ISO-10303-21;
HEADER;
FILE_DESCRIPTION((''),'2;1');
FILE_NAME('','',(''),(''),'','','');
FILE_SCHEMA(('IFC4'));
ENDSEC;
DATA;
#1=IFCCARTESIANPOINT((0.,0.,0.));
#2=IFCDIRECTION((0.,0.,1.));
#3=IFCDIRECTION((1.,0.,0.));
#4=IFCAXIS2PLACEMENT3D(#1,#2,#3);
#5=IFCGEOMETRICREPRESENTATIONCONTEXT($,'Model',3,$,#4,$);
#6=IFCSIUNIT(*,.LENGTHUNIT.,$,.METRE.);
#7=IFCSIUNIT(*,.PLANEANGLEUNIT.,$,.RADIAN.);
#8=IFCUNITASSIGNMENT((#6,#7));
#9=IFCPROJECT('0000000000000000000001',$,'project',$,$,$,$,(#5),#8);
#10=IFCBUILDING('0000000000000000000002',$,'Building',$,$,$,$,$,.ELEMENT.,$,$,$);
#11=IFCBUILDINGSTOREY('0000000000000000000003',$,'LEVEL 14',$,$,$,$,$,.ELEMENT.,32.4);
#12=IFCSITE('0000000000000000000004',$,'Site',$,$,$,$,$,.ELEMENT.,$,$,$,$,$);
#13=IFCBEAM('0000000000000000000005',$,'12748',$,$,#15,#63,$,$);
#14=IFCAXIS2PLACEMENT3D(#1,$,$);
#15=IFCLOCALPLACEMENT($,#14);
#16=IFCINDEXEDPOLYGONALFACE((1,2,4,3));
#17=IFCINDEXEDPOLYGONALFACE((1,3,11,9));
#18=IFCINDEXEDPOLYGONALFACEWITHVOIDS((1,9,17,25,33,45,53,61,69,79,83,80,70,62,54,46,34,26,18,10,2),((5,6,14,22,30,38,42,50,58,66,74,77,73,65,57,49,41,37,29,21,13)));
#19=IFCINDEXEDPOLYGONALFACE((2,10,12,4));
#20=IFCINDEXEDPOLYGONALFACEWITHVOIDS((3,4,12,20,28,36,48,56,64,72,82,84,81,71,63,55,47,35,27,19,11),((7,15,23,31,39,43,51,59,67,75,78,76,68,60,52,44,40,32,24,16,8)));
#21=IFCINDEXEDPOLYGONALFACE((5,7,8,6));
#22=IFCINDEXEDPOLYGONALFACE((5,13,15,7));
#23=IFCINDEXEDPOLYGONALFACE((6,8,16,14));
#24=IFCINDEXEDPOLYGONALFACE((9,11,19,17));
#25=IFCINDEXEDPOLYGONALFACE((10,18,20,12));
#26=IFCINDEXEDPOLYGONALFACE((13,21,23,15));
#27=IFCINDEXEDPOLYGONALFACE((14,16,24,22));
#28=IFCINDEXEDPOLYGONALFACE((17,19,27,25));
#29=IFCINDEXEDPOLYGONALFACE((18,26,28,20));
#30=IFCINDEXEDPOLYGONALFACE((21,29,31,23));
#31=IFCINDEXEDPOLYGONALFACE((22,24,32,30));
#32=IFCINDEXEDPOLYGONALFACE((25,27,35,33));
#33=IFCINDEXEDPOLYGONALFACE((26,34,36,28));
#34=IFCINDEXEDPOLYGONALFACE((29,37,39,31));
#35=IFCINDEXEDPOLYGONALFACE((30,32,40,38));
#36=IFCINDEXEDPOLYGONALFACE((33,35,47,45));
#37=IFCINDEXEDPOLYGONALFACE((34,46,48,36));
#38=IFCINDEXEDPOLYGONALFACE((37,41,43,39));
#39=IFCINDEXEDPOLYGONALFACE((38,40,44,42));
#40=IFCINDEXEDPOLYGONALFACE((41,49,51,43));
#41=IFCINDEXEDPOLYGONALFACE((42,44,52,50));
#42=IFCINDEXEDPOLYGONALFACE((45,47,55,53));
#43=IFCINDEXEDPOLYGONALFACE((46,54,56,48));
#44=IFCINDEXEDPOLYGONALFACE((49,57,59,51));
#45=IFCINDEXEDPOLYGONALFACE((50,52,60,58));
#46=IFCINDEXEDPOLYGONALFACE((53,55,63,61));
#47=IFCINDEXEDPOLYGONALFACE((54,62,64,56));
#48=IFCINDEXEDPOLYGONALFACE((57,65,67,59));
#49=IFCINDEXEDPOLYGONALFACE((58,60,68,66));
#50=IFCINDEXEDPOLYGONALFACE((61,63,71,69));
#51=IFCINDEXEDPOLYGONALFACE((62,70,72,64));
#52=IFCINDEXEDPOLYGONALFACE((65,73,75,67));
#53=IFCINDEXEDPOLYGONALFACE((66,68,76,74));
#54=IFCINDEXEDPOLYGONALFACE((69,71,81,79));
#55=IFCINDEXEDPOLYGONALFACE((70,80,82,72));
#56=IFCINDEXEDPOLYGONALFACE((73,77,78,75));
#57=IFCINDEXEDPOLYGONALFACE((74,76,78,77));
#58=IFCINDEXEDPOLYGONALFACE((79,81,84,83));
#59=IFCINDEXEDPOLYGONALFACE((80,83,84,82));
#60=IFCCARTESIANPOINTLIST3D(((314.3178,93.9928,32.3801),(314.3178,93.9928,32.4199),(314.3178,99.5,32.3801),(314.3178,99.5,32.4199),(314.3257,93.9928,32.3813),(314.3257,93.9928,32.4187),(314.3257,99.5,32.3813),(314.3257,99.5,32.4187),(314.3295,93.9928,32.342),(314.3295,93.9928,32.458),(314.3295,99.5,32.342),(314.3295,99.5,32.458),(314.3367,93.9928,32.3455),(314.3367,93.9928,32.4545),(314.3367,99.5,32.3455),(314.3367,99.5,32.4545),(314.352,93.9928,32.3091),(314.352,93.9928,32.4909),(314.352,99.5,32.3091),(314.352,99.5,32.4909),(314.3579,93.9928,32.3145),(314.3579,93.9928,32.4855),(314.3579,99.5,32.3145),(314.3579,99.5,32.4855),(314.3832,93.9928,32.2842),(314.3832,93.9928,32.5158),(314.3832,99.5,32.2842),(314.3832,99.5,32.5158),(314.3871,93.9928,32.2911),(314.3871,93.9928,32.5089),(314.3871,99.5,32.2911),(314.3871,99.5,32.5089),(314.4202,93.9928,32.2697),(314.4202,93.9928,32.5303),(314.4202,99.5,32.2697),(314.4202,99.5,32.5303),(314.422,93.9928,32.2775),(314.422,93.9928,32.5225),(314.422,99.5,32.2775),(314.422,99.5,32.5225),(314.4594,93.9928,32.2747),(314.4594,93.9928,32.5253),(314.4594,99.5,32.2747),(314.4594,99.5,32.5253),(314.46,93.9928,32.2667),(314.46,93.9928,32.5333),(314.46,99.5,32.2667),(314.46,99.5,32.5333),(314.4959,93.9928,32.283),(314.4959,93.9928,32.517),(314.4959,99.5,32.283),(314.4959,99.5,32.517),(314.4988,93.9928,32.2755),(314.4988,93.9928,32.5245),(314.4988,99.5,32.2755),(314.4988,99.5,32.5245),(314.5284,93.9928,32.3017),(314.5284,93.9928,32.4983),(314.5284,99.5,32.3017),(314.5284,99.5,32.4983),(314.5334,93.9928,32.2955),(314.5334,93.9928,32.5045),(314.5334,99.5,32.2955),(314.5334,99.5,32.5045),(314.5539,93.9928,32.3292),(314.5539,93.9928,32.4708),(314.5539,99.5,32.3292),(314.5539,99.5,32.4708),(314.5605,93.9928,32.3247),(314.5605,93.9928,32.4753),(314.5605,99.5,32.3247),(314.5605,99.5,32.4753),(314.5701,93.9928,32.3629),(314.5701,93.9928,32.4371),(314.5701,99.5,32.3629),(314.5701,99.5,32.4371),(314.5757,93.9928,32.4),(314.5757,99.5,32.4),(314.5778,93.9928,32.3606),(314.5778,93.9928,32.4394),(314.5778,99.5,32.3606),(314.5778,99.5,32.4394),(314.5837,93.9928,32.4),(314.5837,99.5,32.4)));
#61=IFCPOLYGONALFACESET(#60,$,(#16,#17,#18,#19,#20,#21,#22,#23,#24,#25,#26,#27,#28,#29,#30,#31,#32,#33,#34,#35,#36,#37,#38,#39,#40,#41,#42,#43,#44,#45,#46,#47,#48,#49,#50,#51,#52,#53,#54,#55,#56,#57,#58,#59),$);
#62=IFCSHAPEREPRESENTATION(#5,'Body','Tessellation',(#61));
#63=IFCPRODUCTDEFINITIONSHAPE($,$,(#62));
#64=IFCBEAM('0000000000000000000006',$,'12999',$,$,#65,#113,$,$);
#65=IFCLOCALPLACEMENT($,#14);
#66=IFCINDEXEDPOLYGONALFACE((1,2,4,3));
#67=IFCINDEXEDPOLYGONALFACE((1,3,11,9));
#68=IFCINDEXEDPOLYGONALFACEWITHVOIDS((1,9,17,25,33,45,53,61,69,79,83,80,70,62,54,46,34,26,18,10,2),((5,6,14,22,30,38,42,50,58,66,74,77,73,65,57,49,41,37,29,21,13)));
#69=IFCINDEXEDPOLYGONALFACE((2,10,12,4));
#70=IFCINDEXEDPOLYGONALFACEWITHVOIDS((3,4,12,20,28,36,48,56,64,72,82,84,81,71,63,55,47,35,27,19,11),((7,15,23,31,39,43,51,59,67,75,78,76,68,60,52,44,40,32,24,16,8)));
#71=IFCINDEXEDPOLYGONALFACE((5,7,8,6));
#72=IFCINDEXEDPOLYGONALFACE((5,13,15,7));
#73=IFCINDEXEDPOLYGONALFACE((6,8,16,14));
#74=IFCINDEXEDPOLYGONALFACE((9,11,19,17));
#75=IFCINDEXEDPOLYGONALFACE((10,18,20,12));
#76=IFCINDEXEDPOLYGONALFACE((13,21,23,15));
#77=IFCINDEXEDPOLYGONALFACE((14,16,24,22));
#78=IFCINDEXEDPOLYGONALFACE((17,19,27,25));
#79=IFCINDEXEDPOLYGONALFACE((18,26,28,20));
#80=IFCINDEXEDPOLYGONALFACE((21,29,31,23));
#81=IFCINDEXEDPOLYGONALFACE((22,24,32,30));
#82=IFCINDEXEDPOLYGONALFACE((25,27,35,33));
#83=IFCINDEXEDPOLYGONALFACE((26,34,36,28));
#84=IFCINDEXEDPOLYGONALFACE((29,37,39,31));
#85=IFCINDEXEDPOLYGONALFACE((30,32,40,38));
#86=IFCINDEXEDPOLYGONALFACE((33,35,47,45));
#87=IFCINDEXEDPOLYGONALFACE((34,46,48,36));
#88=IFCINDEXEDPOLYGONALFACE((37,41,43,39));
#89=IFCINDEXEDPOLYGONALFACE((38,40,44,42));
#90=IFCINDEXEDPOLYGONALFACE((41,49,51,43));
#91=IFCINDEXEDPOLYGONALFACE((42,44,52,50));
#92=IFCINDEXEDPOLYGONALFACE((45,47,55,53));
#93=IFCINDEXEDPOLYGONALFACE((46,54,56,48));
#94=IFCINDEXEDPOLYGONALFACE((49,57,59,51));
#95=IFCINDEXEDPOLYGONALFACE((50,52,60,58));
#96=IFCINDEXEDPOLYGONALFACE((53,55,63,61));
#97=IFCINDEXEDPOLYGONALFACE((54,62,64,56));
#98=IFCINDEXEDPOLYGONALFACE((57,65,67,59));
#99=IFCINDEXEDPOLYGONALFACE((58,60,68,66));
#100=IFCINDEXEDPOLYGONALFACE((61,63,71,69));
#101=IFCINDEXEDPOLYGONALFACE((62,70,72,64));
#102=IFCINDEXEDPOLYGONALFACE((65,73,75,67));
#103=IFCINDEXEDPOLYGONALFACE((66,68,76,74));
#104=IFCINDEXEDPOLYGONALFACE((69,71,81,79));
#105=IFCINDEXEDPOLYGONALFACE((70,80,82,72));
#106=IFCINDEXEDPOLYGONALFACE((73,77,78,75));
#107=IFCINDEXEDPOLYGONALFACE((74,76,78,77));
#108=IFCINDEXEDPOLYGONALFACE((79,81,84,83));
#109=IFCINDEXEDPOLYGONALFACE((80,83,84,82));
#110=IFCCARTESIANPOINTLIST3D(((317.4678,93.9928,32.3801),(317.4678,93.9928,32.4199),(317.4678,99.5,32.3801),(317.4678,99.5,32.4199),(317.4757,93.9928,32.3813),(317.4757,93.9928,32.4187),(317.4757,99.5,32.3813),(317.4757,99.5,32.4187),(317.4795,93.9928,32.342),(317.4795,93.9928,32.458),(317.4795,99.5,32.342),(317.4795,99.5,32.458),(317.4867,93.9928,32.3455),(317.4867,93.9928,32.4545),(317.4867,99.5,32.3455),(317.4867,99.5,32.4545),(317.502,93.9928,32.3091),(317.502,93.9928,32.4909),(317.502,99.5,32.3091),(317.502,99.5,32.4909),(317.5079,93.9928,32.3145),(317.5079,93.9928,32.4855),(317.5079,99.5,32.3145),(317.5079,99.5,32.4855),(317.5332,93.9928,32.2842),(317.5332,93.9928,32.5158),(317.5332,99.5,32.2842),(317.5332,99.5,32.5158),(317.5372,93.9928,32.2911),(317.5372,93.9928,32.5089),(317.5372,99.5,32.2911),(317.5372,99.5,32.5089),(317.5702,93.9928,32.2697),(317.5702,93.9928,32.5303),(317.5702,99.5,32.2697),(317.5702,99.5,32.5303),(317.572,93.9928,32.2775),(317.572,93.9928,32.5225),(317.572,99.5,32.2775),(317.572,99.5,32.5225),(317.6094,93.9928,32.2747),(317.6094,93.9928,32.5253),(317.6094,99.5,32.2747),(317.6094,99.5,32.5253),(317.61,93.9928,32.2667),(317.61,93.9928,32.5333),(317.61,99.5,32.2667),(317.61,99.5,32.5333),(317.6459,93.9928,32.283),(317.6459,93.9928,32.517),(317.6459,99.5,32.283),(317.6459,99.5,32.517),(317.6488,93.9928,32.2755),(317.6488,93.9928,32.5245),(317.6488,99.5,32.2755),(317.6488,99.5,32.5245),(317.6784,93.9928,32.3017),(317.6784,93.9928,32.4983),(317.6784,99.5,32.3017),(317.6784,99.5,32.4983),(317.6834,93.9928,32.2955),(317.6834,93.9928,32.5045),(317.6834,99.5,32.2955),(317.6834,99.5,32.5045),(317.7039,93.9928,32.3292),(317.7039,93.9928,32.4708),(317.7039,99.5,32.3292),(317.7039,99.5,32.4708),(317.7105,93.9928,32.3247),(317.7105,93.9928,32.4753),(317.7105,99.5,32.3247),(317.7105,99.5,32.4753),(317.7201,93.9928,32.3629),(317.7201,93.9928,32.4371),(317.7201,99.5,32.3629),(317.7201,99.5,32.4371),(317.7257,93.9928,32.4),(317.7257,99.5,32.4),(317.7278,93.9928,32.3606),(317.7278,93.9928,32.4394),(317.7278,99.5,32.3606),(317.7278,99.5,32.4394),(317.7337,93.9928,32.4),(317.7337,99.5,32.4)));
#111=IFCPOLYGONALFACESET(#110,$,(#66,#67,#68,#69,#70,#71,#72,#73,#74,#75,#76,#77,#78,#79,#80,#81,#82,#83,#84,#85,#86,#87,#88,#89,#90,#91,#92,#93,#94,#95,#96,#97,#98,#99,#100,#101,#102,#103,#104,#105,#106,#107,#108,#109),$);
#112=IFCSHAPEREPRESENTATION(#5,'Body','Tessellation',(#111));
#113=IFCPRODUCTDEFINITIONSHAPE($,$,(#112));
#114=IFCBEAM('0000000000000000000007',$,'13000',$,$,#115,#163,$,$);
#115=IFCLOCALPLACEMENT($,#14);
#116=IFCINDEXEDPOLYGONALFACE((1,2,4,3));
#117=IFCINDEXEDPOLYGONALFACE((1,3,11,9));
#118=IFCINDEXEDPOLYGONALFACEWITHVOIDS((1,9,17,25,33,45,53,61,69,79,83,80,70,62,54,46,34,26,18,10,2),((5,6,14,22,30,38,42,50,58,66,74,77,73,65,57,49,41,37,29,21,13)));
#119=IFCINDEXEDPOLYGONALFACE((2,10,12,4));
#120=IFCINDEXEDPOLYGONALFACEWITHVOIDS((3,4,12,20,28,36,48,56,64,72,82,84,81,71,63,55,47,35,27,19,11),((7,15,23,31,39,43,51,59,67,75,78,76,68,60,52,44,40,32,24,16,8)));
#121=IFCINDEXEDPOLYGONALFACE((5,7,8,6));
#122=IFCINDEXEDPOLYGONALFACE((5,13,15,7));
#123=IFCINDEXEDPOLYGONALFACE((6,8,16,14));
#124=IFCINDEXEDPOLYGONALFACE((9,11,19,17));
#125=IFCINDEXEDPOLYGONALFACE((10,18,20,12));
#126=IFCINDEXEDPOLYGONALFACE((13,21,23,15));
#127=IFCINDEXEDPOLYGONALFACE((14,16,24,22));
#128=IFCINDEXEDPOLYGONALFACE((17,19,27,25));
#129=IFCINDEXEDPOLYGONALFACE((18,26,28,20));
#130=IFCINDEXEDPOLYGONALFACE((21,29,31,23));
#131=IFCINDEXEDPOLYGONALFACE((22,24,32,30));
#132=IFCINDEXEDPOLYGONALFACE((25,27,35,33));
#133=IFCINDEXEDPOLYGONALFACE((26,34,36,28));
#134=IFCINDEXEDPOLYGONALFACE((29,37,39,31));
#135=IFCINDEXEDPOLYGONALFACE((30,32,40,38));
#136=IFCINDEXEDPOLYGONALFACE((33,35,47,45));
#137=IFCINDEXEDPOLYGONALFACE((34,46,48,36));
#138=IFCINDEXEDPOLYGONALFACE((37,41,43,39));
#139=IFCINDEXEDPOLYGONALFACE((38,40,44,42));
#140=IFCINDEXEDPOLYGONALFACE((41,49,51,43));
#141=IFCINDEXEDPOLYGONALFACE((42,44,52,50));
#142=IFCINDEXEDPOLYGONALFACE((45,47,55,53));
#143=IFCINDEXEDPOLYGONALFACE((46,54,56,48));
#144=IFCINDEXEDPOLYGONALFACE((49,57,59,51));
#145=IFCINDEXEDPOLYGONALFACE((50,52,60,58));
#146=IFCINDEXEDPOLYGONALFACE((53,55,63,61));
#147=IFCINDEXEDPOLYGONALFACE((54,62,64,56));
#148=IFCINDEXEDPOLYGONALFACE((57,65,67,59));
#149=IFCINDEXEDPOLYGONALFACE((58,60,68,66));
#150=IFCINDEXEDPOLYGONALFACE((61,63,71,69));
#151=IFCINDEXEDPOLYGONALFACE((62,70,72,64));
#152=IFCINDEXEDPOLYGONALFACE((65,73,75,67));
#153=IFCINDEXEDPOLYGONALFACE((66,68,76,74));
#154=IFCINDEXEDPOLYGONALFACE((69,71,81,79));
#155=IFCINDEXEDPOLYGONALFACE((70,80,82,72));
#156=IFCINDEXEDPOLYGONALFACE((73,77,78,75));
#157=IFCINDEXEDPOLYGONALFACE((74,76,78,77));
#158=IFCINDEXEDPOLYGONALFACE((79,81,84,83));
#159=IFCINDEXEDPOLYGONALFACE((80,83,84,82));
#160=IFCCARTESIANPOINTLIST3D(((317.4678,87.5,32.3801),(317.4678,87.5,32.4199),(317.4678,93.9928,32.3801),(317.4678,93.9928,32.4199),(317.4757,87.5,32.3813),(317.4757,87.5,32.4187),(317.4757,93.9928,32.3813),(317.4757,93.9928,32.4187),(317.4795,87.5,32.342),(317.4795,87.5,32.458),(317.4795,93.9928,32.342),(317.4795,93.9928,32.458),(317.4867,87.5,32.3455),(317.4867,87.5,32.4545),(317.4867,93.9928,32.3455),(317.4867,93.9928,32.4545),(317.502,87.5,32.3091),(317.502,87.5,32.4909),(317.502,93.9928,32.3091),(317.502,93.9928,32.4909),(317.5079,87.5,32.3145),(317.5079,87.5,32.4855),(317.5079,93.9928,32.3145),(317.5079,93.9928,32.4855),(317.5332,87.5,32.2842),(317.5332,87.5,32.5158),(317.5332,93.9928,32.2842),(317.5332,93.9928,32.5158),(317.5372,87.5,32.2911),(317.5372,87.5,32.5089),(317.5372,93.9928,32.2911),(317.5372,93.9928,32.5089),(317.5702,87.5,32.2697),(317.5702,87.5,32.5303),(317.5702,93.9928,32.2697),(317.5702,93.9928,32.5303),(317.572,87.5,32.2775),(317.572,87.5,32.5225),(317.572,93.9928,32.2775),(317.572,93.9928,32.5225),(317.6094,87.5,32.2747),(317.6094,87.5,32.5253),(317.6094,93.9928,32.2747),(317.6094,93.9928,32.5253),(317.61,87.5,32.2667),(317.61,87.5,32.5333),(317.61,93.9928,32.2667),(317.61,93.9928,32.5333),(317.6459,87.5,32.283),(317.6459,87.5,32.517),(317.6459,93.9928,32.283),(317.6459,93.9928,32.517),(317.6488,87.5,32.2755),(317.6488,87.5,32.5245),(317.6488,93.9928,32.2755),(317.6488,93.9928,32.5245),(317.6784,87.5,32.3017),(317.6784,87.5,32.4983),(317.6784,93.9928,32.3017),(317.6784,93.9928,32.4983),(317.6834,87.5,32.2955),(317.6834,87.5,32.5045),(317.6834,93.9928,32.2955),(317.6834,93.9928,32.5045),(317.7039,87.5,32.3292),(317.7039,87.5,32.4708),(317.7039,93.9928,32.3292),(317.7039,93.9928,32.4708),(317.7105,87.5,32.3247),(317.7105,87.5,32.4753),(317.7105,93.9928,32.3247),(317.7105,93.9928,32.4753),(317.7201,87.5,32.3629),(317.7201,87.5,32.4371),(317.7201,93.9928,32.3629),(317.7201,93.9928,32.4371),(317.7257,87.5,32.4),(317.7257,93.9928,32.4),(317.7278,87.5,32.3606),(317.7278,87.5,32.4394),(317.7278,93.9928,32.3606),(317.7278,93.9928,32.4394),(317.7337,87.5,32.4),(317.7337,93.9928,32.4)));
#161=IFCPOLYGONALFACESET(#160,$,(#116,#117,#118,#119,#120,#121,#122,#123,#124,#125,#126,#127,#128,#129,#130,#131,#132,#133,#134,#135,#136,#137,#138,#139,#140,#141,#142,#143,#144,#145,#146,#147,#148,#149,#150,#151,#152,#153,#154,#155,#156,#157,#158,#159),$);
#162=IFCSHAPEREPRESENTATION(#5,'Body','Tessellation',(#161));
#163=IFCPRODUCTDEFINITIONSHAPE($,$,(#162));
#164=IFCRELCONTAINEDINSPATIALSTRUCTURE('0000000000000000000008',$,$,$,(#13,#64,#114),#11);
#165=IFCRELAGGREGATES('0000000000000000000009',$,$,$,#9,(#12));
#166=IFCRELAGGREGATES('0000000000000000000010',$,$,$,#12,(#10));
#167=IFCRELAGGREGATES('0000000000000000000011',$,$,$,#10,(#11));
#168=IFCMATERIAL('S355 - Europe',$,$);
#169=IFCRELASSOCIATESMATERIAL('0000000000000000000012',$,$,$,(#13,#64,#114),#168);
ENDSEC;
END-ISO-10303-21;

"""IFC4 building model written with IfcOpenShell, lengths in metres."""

from ifc_helpers import new_model, si_unit, frame, origin_with_axes, origin_2d_with_axis, place, context, project, spatial, hollow_circle, extrude, material, material_profile, profile_set, profile_usage, element, save


model = new_model("IFC4")

# Units and contexts
model_context = context("Model", 3, world=origin_with_axes())
ifc_project = project(units=[si_unit("LENGTHUNIT", "METRE"), si_unit("PLANEANGLEUNIT", "RADIAN")], contexts=[model_context])

# Site, building, storey
site = spatial("IfcSite", under=ifc_project, Name="Site", CompositionType="ELEMENT")
building = spatial("IfcBuilding", under=site, Name="Building", CompositionType="ELEMENT")
storey = spatial("IfcBuildingStorey", under=building, Name="LEVEL 14", CompositionType="ELEMENT", Elevation=32.4)

# Shared definitions
ifc_material = material(Name="S355 - Europe")

# Beams
ifc_material_profile_1 = material_profile(ifc_material, hollow_circle(Radius=0.1337, WallThickness=0.008, at=origin_2d_with_axis()))
ifc_profile_set_1 = profile_set([ifc_material_profile_1])
ifc_profile_usage_1 = profile_usage(ifc_profile_set_1, cardinal=10)
beam_1_placement = place(None, frame((314.45, 99.5, 32.4), z_axis=(0.0, -1.0, 0.0), x_axis=(1.0, 0.0, 0.0)))
element("IfcBeam", 1, at=beam_1_placement, inside=storey, material=ifc_profile_usage_1, Name="12748", context=model_context, shape_type="SweptSolid", body=[
    extrude(hollow_circle(Radius=0.1337, WallThickness=0.008, at=origin_2d_with_axis()), origin_with_axes(), (0.0, 0.0, 1.0), 5.5072),
])
ifc_material_profile_2 = material_profile(ifc_material, hollow_circle(Radius=0.1337, WallThickness=0.008, at=origin_2d_with_axis()))
ifc_profile_set_2 = profile_set([ifc_material_profile_2])
ifc_profile_usage_2 = profile_usage(ifc_profile_set_2, cardinal=10)
beam_2_placement = place(None, frame((317.6, 99.5, 32.4), z_axis=(0.0, -1.0, 0.0), x_axis=(1.0, 0.0, 0.0)))
element("IfcBeam", 2, at=beam_2_placement, inside=storey, material=ifc_profile_usage_2, Name="12999", context=model_context, shape_type="SweptSolid", body=[
    extrude(hollow_circle(Radius=0.1337, WallThickness=0.008, at=origin_2d_with_axis()), origin_with_axes(), (0.0, 0.0, 1.0), 5.5072),
])
ifc_material_profile_3 = material_profile(ifc_material, hollow_circle(Radius=0.1337, WallThickness=0.008, at=origin_2d_with_axis()))
ifc_profile_set_3 = profile_set([ifc_material_profile_3])
ifc_profile_usage_3 = profile_usage(ifc_profile_set_3, cardinal=10)
beam_3_placement = place(None, frame((317.6, 93.9928, 32.4), z_axis=(0.0, -1.0, 0.0), x_axis=(1.0, 0.0, 0.0)))
element("IfcBeam", 3, at=beam_3_placement, inside=storey, material=ifc_profile_usage_3, Name="13000", context=model_context, shape_type="SweptSolid", body=[
    extrude(hollow_circle(Radius=0.1337, WallThickness=0.008, at=origin_2d_with_axis()), origin_with_axes(), (0.0, 0.0, 1.0), 6.4928),
])

save(model, "model.ifc")
